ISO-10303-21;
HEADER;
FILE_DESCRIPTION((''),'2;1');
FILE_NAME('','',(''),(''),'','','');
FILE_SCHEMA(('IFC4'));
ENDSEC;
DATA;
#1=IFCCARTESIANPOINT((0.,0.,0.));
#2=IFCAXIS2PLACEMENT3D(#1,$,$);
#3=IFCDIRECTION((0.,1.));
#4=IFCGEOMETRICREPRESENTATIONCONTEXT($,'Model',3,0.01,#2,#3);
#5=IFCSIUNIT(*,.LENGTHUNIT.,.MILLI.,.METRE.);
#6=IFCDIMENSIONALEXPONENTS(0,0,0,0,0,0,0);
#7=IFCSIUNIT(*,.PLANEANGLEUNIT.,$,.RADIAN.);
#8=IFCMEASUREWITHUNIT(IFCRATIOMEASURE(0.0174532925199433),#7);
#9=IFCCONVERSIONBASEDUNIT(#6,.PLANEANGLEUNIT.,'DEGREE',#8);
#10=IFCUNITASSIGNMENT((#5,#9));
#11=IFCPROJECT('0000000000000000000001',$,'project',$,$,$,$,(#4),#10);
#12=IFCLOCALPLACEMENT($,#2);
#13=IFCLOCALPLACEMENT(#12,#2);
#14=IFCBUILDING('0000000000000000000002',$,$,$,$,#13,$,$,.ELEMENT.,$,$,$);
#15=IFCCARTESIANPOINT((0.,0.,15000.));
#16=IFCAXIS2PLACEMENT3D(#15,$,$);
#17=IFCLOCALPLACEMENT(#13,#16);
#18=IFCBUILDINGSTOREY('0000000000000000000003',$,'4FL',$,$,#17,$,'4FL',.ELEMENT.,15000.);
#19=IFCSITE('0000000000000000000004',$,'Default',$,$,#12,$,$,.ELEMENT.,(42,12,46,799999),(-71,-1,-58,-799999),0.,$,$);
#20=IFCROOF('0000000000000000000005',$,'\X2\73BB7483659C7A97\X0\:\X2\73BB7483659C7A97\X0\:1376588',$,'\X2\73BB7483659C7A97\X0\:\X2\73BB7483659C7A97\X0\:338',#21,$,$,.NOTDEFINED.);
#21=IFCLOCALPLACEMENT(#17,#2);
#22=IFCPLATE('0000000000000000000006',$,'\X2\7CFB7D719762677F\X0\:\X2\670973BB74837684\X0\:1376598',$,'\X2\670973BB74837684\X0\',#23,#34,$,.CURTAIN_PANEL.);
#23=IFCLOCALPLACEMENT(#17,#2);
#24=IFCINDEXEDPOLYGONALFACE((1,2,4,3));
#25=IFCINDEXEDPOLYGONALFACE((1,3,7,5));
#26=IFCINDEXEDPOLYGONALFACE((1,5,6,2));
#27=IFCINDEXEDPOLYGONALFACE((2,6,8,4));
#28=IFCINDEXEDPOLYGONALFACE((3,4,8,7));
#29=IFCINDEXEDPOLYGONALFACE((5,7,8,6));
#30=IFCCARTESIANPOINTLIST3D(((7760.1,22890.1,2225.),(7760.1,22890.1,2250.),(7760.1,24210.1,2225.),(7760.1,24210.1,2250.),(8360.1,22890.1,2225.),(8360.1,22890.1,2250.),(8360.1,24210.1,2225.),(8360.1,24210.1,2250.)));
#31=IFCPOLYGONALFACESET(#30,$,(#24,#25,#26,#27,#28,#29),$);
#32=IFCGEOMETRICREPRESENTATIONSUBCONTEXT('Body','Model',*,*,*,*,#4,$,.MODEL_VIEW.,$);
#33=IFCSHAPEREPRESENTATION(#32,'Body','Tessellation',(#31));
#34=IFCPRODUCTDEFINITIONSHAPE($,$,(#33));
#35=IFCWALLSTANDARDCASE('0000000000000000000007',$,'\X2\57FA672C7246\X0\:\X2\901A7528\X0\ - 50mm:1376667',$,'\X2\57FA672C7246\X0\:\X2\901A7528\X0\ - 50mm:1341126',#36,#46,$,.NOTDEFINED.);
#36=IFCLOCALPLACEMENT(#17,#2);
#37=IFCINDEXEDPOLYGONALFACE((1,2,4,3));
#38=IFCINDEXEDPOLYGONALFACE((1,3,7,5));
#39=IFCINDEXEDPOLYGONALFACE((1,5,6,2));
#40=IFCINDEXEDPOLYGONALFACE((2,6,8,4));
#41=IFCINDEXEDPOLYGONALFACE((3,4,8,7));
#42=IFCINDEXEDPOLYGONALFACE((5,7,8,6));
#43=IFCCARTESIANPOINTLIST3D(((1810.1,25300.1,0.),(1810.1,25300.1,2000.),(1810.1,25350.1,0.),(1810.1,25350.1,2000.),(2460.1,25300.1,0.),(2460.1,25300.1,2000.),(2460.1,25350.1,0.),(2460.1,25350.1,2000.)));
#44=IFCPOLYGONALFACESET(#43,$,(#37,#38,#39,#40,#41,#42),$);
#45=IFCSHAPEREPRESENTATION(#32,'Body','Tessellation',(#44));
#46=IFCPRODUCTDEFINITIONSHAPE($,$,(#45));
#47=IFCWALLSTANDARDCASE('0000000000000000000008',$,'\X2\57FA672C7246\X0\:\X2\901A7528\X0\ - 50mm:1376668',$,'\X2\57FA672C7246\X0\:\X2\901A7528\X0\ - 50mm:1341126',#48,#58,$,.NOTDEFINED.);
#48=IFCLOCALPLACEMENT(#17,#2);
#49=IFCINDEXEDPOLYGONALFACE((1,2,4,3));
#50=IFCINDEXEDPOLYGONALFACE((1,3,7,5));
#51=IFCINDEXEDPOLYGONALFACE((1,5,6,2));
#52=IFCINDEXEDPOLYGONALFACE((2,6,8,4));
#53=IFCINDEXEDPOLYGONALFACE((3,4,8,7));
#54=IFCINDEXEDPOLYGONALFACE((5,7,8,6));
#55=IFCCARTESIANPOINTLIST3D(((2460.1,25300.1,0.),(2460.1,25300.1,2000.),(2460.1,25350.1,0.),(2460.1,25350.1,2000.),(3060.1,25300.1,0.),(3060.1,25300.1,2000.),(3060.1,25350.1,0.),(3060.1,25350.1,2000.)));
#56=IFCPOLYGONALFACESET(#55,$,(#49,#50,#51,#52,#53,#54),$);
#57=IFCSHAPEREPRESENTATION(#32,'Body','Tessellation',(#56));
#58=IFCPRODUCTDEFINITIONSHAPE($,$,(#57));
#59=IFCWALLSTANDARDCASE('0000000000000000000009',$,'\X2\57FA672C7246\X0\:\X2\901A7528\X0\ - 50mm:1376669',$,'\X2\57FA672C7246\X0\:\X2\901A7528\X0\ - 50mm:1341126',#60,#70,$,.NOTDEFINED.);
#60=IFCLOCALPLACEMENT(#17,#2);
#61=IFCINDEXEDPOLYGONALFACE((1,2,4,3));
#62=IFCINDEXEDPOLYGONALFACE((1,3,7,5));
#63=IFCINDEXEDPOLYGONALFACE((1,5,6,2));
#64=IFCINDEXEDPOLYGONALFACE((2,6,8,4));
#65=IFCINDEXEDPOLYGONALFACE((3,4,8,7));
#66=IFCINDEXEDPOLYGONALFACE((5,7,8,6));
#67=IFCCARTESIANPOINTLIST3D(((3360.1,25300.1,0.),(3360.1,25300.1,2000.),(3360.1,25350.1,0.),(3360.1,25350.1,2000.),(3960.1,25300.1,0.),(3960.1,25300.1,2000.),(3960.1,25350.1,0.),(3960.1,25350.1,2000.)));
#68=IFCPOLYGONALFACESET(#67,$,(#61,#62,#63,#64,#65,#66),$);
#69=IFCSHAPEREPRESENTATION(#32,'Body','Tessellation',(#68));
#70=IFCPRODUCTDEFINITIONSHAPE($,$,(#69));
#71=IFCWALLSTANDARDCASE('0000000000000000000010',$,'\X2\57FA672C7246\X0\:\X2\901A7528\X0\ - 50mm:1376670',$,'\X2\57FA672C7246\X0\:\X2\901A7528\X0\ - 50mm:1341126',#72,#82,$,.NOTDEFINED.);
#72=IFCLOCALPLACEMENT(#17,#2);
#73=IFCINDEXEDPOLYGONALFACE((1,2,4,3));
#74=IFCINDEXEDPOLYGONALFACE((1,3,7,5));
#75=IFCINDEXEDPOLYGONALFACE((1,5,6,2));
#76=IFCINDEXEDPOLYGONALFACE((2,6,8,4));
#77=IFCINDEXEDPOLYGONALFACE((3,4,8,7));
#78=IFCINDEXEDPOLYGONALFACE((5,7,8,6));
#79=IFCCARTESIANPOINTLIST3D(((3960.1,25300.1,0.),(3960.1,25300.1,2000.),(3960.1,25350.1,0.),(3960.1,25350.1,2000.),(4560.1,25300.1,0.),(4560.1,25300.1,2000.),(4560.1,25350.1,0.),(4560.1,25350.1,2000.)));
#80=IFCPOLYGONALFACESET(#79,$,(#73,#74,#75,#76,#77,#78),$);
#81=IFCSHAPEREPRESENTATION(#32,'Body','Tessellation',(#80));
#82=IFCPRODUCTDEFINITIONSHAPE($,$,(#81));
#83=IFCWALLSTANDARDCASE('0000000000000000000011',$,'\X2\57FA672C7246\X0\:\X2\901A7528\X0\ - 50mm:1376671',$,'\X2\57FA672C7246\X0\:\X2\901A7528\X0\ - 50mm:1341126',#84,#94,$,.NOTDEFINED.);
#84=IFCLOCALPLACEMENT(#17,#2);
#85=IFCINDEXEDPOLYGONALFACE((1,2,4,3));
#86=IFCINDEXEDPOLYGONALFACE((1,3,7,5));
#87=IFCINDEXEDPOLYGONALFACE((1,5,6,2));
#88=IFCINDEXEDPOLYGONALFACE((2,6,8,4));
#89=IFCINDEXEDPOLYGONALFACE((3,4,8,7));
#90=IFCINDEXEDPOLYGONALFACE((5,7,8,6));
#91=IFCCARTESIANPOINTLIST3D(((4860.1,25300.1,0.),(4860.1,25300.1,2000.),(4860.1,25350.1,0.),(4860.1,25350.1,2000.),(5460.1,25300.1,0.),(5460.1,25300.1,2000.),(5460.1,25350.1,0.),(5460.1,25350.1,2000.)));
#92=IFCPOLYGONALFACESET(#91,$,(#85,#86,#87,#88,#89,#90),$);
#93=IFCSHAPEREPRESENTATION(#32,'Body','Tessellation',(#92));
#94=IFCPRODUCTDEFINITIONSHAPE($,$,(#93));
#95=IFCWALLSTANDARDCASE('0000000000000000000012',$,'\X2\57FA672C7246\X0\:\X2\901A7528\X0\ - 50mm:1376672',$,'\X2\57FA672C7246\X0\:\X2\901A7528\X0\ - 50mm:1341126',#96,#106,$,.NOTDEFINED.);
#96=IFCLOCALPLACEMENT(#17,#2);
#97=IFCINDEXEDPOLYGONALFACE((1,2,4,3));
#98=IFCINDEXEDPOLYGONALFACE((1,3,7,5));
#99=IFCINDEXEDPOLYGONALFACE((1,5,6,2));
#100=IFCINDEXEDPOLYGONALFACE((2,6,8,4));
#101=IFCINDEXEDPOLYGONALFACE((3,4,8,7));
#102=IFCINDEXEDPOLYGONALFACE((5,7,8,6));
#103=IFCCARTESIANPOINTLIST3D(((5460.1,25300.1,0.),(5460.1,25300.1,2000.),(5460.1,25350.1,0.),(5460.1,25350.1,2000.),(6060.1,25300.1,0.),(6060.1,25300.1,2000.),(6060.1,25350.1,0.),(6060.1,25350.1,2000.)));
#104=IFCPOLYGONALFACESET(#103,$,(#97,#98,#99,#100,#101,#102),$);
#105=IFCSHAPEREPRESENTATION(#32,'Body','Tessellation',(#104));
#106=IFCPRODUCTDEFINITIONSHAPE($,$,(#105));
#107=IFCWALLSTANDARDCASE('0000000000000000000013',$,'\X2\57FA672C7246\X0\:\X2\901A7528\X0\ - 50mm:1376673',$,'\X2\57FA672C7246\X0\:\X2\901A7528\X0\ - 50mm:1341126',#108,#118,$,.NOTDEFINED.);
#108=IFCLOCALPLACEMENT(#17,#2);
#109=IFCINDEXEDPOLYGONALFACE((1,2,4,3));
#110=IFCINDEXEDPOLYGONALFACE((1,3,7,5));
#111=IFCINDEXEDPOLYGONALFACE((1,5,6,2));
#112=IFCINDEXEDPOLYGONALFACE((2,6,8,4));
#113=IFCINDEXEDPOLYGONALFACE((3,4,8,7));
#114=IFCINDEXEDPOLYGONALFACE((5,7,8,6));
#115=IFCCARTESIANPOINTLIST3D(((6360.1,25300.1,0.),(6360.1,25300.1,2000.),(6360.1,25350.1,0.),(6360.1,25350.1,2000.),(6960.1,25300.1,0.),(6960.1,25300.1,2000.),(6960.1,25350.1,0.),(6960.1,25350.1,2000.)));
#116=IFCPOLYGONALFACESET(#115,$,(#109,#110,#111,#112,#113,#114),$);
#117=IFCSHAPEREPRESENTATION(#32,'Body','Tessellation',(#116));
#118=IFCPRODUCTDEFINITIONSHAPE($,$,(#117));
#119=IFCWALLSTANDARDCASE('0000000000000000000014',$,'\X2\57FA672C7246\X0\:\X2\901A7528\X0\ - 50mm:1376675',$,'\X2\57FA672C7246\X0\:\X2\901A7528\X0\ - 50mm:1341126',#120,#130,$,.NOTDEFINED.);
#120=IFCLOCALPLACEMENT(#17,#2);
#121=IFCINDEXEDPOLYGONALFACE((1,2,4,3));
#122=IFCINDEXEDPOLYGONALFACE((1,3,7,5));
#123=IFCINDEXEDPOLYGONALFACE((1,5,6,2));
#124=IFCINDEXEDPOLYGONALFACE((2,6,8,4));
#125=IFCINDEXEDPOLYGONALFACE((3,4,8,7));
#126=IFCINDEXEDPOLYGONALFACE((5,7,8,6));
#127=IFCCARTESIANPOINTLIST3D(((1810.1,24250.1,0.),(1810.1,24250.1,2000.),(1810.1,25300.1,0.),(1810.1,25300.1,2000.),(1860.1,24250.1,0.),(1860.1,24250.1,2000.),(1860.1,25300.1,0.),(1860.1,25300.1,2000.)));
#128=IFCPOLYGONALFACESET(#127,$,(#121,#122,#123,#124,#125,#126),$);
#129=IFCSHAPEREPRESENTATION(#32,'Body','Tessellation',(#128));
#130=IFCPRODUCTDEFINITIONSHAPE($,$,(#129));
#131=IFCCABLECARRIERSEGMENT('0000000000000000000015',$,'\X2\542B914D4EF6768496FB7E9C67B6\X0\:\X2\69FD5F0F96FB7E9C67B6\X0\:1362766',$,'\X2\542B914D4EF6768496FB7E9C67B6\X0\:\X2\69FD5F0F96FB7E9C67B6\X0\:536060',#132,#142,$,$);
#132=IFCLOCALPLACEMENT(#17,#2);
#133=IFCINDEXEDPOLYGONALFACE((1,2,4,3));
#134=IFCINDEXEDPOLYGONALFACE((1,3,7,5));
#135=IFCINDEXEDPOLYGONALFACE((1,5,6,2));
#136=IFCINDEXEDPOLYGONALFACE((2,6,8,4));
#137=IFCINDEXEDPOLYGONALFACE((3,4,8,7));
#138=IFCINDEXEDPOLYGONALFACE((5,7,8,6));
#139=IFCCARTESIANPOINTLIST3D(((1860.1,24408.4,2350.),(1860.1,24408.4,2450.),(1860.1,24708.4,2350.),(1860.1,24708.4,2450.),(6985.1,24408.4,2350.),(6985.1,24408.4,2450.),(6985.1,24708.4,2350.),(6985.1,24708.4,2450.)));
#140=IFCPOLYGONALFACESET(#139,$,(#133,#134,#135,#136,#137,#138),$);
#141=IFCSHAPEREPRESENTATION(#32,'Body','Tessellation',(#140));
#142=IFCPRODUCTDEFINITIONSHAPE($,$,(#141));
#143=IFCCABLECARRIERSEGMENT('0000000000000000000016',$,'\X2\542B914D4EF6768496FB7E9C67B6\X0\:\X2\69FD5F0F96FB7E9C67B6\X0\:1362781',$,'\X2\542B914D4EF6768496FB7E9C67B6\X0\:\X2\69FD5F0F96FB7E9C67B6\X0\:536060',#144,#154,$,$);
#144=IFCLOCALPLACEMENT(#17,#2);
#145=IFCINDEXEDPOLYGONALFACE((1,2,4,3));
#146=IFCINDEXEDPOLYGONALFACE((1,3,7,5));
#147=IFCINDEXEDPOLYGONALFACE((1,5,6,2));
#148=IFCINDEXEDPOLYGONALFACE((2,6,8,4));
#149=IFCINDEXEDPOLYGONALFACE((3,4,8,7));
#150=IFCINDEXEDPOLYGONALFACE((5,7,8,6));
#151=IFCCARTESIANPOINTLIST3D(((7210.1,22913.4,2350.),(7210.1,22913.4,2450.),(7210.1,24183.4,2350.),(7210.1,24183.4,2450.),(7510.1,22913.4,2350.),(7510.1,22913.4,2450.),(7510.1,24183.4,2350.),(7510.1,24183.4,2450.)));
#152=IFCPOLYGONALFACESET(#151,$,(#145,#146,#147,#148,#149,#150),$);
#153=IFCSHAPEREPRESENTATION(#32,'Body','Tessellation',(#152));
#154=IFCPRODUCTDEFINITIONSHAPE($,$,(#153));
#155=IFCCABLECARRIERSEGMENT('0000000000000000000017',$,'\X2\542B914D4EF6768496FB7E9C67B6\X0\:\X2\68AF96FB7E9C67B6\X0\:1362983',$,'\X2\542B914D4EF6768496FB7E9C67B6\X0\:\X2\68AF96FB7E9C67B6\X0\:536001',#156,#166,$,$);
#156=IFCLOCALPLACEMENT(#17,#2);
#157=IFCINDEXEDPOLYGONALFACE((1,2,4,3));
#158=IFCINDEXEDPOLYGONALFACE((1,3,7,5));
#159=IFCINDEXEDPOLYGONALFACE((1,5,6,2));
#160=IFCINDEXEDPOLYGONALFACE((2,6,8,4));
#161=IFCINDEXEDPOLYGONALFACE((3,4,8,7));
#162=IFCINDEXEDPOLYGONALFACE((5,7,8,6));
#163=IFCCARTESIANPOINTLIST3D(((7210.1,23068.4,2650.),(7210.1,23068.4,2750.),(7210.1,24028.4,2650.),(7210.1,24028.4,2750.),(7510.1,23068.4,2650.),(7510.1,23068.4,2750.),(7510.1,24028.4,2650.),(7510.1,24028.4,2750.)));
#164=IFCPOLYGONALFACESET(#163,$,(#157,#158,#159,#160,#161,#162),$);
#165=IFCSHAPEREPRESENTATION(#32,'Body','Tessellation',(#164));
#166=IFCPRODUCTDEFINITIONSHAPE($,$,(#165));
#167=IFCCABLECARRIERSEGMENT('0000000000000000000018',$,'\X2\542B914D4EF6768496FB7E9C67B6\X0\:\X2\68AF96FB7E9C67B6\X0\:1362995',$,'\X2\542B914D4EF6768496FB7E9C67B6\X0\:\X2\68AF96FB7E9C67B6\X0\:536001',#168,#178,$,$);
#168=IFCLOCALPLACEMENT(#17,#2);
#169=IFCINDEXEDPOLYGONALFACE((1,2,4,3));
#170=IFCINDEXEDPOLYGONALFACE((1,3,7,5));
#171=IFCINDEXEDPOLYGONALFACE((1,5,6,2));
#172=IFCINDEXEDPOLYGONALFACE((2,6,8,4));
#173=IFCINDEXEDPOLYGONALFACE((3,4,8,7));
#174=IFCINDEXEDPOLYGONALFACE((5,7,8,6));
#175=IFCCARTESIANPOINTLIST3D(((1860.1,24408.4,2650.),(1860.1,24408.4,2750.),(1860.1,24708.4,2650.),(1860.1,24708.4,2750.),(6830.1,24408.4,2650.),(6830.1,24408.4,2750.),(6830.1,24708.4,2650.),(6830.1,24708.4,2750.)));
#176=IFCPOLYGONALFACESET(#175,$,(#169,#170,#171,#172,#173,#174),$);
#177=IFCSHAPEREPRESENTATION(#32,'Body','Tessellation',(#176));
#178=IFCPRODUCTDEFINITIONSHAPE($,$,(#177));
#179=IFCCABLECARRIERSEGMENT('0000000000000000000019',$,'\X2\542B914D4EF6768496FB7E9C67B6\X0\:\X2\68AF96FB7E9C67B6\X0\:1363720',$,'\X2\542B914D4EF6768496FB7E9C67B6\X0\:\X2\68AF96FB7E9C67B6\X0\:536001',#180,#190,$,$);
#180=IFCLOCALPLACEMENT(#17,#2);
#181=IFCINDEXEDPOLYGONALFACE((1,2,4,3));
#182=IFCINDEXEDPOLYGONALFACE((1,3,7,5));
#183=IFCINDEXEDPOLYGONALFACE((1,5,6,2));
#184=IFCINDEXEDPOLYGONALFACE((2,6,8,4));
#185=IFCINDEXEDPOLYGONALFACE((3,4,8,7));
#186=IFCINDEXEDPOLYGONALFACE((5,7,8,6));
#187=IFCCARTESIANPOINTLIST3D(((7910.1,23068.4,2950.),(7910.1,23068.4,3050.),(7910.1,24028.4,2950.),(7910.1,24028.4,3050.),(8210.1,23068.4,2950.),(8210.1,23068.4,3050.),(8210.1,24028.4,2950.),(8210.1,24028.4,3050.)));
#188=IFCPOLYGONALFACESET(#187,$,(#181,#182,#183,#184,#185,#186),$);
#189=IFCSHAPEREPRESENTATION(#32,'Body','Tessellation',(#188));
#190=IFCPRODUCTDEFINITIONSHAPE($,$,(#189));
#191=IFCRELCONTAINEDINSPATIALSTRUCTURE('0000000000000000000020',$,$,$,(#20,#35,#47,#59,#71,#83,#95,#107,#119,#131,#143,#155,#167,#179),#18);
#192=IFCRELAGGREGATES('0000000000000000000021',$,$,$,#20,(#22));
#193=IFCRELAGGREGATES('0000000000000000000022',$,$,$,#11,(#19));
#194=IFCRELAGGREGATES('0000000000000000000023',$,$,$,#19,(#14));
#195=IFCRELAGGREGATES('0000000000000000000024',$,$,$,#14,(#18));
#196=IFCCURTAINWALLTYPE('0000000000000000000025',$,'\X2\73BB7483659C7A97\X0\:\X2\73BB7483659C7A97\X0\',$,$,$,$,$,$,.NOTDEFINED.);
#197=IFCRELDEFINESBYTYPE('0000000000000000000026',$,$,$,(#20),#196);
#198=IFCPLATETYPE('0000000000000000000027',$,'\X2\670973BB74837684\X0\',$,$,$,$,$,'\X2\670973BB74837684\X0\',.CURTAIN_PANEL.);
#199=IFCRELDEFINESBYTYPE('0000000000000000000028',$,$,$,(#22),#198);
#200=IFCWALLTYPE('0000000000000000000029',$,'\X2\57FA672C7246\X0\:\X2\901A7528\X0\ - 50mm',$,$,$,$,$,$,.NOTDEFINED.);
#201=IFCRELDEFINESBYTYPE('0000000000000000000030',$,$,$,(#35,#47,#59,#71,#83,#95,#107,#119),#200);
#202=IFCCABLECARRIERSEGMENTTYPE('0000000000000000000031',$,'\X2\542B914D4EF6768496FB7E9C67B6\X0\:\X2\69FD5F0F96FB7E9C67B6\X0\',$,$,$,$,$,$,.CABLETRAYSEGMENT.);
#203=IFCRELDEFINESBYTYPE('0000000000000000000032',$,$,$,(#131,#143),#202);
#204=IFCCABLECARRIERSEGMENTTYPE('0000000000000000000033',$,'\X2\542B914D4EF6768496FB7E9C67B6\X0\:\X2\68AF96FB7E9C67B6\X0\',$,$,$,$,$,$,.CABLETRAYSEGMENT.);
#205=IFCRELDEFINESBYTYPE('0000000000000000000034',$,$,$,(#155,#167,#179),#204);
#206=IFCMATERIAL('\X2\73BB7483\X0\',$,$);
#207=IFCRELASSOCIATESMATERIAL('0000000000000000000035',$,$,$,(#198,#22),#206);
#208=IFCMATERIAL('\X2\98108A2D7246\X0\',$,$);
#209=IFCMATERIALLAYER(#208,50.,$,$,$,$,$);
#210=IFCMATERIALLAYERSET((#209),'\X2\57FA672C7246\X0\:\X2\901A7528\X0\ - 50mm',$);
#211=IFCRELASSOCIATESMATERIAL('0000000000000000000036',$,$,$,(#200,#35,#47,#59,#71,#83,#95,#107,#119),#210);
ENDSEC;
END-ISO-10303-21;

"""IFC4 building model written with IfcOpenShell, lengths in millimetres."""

from ifc_helpers import new_model, entity, si_unit, converted_unit, direction, frame, frame_2d, origin, origin_2d_with_axis, place, context, subcontext, project, spatial, rectangle, extrude, source, transform, mapped, material, layer, layer_set, layer_usage, type_object, type_shapes, element, aggregate, save


model = new_model("IFC4")

# Units and contexts
model_context = context("Model", 3, precision=0.01, world=origin(), true_north=direction((0.0, 1.0)))
body_context = subcontext(model_context, "Body", "Model", "MODEL_VIEW")
ifc_project = project(units=[si_unit("LENGTHUNIT", "METRE", prefix="MILLI"), converted_unit("PLANEANGLEUNIT", "DEGREE", entity("IfcRatioMeasure", 0.0174532925199433), si_unit("PLANEANGLEUNIT", "RADIAN"), dimensions=[0, 0, 0, 0, 0, 0, 0])], contexts=[model_context])

# Site, building, storey
site_placement = place(None, origin())
site = spatial("IfcSite", under=ifc_project, at=site_placement, Name="Default", CompositionType="ELEMENT", RefLatitude=(42, 12, 46, 799999), RefLongitude=(-71, -1, -58, -799999), RefElevation=0.0)
building_placement = place(site_placement, origin())
building = spatial("IfcBuilding", under=site, at=building_placement, CompositionType="ELEMENT")
storey_placement = place(building_placement, frame((0.0, 0.0, 15000.0)))
storey = spatial("IfcBuildingStorey", under=building, at=storey_placement, Name="4FL", LongName="4FL", CompositionType="ELEMENT", Elevation=15000.0)

# Roof, plate
curtain_wall_type = type_object("IfcCurtainWallType", Name="玻璃斜窗:玻璃斜窗", PredefinedType="NOTDEFINED")
roof_placement = place(storey_placement, frame((0.0, 0.0, -15000.0)))
roof = element("IfcRoof", 1, at=roof_placement, inside=storey, type_object=curtain_wall_type, Name="玻璃斜窗:玻璃斜窗:1376588", ObjectType="玻璃斜窗:玻璃斜窗:338", PredefinedType="NOTDEFINED")
ifc_material_1 = material(Name="玻璃")
plate_type = type_object("IfcPlateType", Name="有玻璃的", ElementType="有玻璃的", PredefinedType="CURTAIN_PANEL", material=ifc_material_1)
shared_shape_1 = source(origin(), body_context, "Body", "SweptSolid", [
    extrude(rectangle(XDim=25.0, YDim=600.0, at=origin_2d_with_axis()), frame((300.0, 12.5, 0.0), z_axis=(0.0, 0.0, 1.0), x_axis=(0.0, 1.0, 0.0)), (0.0, 0.0, 1.0), 1320.0),
])
type_shapes(plate_type, [shared_shape_1])
plate_placement = place(roof_placement, frame((7760.1, 22890.1, 17250.0), z_axis=(0.0, 1.0, 0.0), x_axis=(1.0, 0.0, 0.0)))
plate = element("IfcPlate", 2, at=plate_placement, type_object=plate_type, material=ifc_material_1, Name="系統面板:有玻璃的:1376598", ObjectType="有玻璃的", PredefinedType="CURTAIN_PANEL", context=body_context, shape_type="MappedRepresentation", body=[
    mapped(shared_shape_1, transform((0.0, 0.0, 0.0), scale=1.0)),
])
aggregate(roof, [plate])

# Walls
ifc_material_2 = material(Name="預設牆")
ifc_layer = layer(ifc_material_2, 50.0)
ifc_layer_set = layer_set([ifc_layer], Name="基本牆:通用 - 50mm")
ifc_layer_usage_1 = layer_usage(ifc_layer_set, "AXIS2", "NEGATIVE", 25.0)
wall_type = type_object("IfcWallType", Name="基本牆:通用 - 50mm", PredefinedType="NOTDEFINED", material=ifc_layer_set)
wall_1_placement = place(storey_placement, frame((1810.1, 25325.1, 0.0)))
element("IfcWallStandardCase", 3, at=wall_1_placement, inside=storey, type_object=wall_type, material=ifc_layer_usage_1, Name="基本牆:通用 - 50mm:1376667", ObjectType="基本牆:通用 - 50mm:1341126", PredefinedType="NOTDEFINED", context=body_context, shape_type="SweptSolid", body=[
    extrude(rectangle(XDim=650.0, YDim=50.0, at=frame_2d((325.0, 0.0), x_axis=(-1.0, 0.0))), origin(), (0.0, 0.0, 1.0), 2000.0),
])
ifc_layer_usage_2 = layer_usage(ifc_layer_set, "AXIS2", "NEGATIVE", 25.0)
wall_2_placement = place(storey_placement, frame((2460.1, 25325.1, 0.0)))
element("IfcWallStandardCase", 4, at=wall_2_placement, inside=storey, type_object=wall_type, material=ifc_layer_usage_2, Name="基本牆:通用 - 50mm:1376668", ObjectType="基本牆:通用 - 50mm:1341126", PredefinedType="NOTDEFINED", context=body_context, shape_type="SweptSolid", body=[
    extrude(rectangle(XDim=600.0, YDim=50.0, at=frame_2d((300.0, 0.0), x_axis=(-1.0, 0.0))), origin(), (0.0, 0.0, 1.0), 2000.0),
])
ifc_layer_usage_3 = layer_usage(ifc_layer_set, "AXIS2", "NEGATIVE", 25.0)
wall_3_placement = place(storey_placement, frame((3360.1, 25325.1, 0.0)))
element("IfcWallStandardCase", 5, at=wall_3_placement, inside=storey, type_object=wall_type, material=ifc_layer_usage_3, Name="基本牆:通用 - 50mm:1376669", ObjectType="基本牆:通用 - 50mm:1341126", PredefinedType="NOTDEFINED", context=body_context, shape_type="SweptSolid", body=[
    extrude(rectangle(XDim=600.0, YDim=50.0, at=frame_2d((300.0, 0.0), x_axis=(-1.0, 0.0))), origin(), (0.0, 0.0, 1.0), 2000.0),
])
ifc_layer_usage_4 = layer_usage(ifc_layer_set, "AXIS2", "NEGATIVE", 25.0)
wall_4_placement = place(storey_placement, frame((3960.1, 25325.1, 0.0)))
element("IfcWallStandardCase", 6, at=wall_4_placement, inside=storey, type_object=wall_type, material=ifc_layer_usage_4, Name="基本牆:通用 - 50mm:1376670", ObjectType="基本牆:通用 - 50mm:1341126", PredefinedType="NOTDEFINED", context=body_context, shape_type="SweptSolid", body=[
    extrude(rectangle(XDim=600.0, YDim=50.0, at=frame_2d((300.0, 0.0), x_axis=(-1.0, 0.0))), origin(), (0.0, 0.0, 1.0), 2000.0),
])
ifc_layer_usage_5 = layer_usage(ifc_layer_set, "AXIS2", "NEGATIVE", 25.0)
wall_5_placement = place(storey_placement, frame((4860.1, 25325.1, 0.0)))
element("IfcWallStandardCase", 7, at=wall_5_placement, inside=storey, type_object=wall_type, material=ifc_layer_usage_5, Name="基本牆:通用 - 50mm:1376671", ObjectType="基本牆:通用 - 50mm:1341126", PredefinedType="NOTDEFINED", context=body_context, shape_type="SweptSolid", body=[
    extrude(rectangle(XDim=600.0, YDim=50.0, at=frame_2d((300.0, 0.0), x_axis=(-1.0, 0.0))), origin(), (0.0, 0.0, 1.0), 2000.0),
])
ifc_layer_usage_6 = layer_usage(ifc_layer_set, "AXIS2", "NEGATIVE", 25.0)
wall_6_placement = place(storey_placement, frame((5460.1, 25325.1, 0.0)))
element("IfcWallStandardCase", 8, at=wall_6_placement, inside=storey, type_object=wall_type, material=ifc_layer_usage_6, Name="基本牆:通用 - 50mm:1376672", ObjectType="基本牆:通用 - 50mm:1341126", PredefinedType="NOTDEFINED", context=body_context, shape_type="SweptSolid", body=[
    extrude(rectangle(XDim=600.0, YDim=50.0, at=frame_2d((300.0, 0.0), x_axis=(-1.0, 0.0))), origin(), (0.0, 0.0, 1.0), 2000.0),
])
ifc_layer_usage_7 = layer_usage(ifc_layer_set, "AXIS2", "NEGATIVE", 25.0)
wall_7_placement = place(storey_placement, frame((6360.1, 25325.1, 0.0)))
element("IfcWallStandardCase", 9, at=wall_7_placement, inside=storey, type_object=wall_type, material=ifc_layer_usage_7, Name="基本牆:通用 - 50mm:1376673", ObjectType="基本牆:通用 - 50mm:1341126", PredefinedType="NOTDEFINED", context=body_context, shape_type="SweptSolid", body=[
    extrude(rectangle(XDim=600.0, YDim=50.0, at=frame_2d((300.0, 0.0), x_axis=(-1.0, 0.0))), origin(), (0.0, 0.0, 1.0), 2000.0),
])
ifc_layer_usage_8 = layer_usage(ifc_layer_set, "AXIS2", "NEGATIVE", 25.0)
wall_8_placement = place(storey_placement, frame((1835.1, 24250.1, 0.0), z_axis=(0.0, 0.0, 1.0), x_axis=(0.0, 1.0, 0.0)))
element("IfcWallStandardCase", 10, at=wall_8_placement, inside=storey, type_object=wall_type, material=ifc_layer_usage_8, Name="基本牆:通用 - 50mm:1376675", ObjectType="基本牆:通用 - 50mm:1341126", PredefinedType="NOTDEFINED", context=body_context, shape_type="SweptSolid", body=[
    extrude(rectangle(XDim=1050.0, YDim=50.0, at=frame_2d((525.0, 0.0), x_axis=(-1.0, 0.0))), origin(), (0.0, 0.0, 1.0), 2000.0),
])

# Cable carrier segments
cable_carrier_segment_type_1 = type_object("IfcCableCarrierSegmentType", Name="含配件的電纜架:槽式電纜架", PredefinedType="CABLETRAYSEGMENT")
cable_carrier_segment_1_placement = place(storey_placement, frame((1860.1, 24408.4, 2350.0)))
element("IfcCableCarrierSegment", 11, at=cable_carrier_segment_1_placement, inside=storey, type_object=cable_carrier_segment_type_1, Name="含配件的電纜架:槽式電纜架:1362766", ObjectType="含配件的電纜架:槽式電纜架:536060", context=body_context, shape_type="SweptSolid", body=[
    extrude(rectangle(XDim=5125.0, YDim=300.0, at=frame_2d((0.0, 0.0), x_axis=(1.0, 0.0))), frame((2562.5, 150.0, 0.0), z_axis=(0.0, 0.0, 1.0), x_axis=(-1.0, 0.0, 0.0)), (0.0, 0.0, 1.0), 100.0),
])
cable_carrier_segment_2_placement = place(storey_placement, frame((7210.1, 22913.4, 2350.0)))
element("IfcCableCarrierSegment", 12, at=cable_carrier_segment_2_placement, inside=storey, type_object=cable_carrier_segment_type_1, Name="含配件的電纜架:槽式電纜架:1362781", ObjectType="含配件的電纜架:槽式電纜架:536060", context=body_context, shape_type="SweptSolid", body=[
    extrude(rectangle(XDim=1270.0, YDim=300.0, at=origin_2d_with_axis()), frame((150.0, 635.0, 0.0), z_axis=(0.0, 0.0, 1.0), x_axis=(0.0, 1.0, 0.0)), (0.0, 0.0, 1.0), 100.0),
])
cable_carrier_segment_type_2 = type_object("IfcCableCarrierSegmentType", Name="含配件的電纜架:梯電纜架", PredefinedType="CABLETRAYSEGMENT")
cable_carrier_segment_3_placement = place(storey_placement, frame((7210.1, 23068.4, 2650.0)))
element("IfcCableCarrierSegment", 13, at=cable_carrier_segment_3_placement, inside=storey, type_object=cable_carrier_segment_type_2, Name="含配件的電纜架:梯電纜架:1362983", ObjectType="含配件的電纜架:梯電纜架:536001", context=body_context, shape_type="SweptSolid", body=[
    extrude(rectangle(XDim=960.0, YDim=300.0, at=frame_2d((0.0, 0.0), x_axis=(1.0, 0.0))), frame((150.0, 480.0, 0.0), z_axis=(0.0, 0.0, 1.0), x_axis=(0.0, 1.0, 0.0)), (0.0, 0.0, 1.0), 100.0),
])
cable_carrier_segment_4_placement = place(storey_placement, frame((1860.1, 24408.4, 2650.0)))
element("IfcCableCarrierSegment", 14, at=cable_carrier_segment_4_placement, inside=storey, type_object=cable_carrier_segment_type_2, Name="含配件的電纜架:梯電纜架:1362995", ObjectType="含配件的電纜架:梯電纜架:536001", context=body_context, shape_type="SweptSolid", body=[
    extrude(rectangle(XDim=4970.0, YDim=300.0, at=origin_2d_with_axis()), frame((2485.0, 150.0, 0.0)), (0.0, 0.0, 1.0), 100.0),
])
cable_carrier_segment_5_placement = place(storey_placement, frame((7910.1, 23068.4, 2950.0)))
element("IfcCableCarrierSegment", 15, at=cable_carrier_segment_5_placement, inside=storey, type_object=cable_carrier_segment_type_2, Name="含配件的電纜架:梯電纜架:1363720", ObjectType="含配件的電纜架:梯電纜架:536001", context=body_context, shape_type="SweptSolid", body=[
    extrude(rectangle(XDim=960.0, YDim=300.0, at=frame_2d((0.0, 0.0), x_axis=(1.0, 0.0))), frame((150.0, 480.0, 0.0), z_axis=(0.0, 0.0, 1.0), x_axis=(0.0, 1.0, 0.0)), (0.0, 0.0, 1.0), 100.0),
])

save(model, "model.ifc")
